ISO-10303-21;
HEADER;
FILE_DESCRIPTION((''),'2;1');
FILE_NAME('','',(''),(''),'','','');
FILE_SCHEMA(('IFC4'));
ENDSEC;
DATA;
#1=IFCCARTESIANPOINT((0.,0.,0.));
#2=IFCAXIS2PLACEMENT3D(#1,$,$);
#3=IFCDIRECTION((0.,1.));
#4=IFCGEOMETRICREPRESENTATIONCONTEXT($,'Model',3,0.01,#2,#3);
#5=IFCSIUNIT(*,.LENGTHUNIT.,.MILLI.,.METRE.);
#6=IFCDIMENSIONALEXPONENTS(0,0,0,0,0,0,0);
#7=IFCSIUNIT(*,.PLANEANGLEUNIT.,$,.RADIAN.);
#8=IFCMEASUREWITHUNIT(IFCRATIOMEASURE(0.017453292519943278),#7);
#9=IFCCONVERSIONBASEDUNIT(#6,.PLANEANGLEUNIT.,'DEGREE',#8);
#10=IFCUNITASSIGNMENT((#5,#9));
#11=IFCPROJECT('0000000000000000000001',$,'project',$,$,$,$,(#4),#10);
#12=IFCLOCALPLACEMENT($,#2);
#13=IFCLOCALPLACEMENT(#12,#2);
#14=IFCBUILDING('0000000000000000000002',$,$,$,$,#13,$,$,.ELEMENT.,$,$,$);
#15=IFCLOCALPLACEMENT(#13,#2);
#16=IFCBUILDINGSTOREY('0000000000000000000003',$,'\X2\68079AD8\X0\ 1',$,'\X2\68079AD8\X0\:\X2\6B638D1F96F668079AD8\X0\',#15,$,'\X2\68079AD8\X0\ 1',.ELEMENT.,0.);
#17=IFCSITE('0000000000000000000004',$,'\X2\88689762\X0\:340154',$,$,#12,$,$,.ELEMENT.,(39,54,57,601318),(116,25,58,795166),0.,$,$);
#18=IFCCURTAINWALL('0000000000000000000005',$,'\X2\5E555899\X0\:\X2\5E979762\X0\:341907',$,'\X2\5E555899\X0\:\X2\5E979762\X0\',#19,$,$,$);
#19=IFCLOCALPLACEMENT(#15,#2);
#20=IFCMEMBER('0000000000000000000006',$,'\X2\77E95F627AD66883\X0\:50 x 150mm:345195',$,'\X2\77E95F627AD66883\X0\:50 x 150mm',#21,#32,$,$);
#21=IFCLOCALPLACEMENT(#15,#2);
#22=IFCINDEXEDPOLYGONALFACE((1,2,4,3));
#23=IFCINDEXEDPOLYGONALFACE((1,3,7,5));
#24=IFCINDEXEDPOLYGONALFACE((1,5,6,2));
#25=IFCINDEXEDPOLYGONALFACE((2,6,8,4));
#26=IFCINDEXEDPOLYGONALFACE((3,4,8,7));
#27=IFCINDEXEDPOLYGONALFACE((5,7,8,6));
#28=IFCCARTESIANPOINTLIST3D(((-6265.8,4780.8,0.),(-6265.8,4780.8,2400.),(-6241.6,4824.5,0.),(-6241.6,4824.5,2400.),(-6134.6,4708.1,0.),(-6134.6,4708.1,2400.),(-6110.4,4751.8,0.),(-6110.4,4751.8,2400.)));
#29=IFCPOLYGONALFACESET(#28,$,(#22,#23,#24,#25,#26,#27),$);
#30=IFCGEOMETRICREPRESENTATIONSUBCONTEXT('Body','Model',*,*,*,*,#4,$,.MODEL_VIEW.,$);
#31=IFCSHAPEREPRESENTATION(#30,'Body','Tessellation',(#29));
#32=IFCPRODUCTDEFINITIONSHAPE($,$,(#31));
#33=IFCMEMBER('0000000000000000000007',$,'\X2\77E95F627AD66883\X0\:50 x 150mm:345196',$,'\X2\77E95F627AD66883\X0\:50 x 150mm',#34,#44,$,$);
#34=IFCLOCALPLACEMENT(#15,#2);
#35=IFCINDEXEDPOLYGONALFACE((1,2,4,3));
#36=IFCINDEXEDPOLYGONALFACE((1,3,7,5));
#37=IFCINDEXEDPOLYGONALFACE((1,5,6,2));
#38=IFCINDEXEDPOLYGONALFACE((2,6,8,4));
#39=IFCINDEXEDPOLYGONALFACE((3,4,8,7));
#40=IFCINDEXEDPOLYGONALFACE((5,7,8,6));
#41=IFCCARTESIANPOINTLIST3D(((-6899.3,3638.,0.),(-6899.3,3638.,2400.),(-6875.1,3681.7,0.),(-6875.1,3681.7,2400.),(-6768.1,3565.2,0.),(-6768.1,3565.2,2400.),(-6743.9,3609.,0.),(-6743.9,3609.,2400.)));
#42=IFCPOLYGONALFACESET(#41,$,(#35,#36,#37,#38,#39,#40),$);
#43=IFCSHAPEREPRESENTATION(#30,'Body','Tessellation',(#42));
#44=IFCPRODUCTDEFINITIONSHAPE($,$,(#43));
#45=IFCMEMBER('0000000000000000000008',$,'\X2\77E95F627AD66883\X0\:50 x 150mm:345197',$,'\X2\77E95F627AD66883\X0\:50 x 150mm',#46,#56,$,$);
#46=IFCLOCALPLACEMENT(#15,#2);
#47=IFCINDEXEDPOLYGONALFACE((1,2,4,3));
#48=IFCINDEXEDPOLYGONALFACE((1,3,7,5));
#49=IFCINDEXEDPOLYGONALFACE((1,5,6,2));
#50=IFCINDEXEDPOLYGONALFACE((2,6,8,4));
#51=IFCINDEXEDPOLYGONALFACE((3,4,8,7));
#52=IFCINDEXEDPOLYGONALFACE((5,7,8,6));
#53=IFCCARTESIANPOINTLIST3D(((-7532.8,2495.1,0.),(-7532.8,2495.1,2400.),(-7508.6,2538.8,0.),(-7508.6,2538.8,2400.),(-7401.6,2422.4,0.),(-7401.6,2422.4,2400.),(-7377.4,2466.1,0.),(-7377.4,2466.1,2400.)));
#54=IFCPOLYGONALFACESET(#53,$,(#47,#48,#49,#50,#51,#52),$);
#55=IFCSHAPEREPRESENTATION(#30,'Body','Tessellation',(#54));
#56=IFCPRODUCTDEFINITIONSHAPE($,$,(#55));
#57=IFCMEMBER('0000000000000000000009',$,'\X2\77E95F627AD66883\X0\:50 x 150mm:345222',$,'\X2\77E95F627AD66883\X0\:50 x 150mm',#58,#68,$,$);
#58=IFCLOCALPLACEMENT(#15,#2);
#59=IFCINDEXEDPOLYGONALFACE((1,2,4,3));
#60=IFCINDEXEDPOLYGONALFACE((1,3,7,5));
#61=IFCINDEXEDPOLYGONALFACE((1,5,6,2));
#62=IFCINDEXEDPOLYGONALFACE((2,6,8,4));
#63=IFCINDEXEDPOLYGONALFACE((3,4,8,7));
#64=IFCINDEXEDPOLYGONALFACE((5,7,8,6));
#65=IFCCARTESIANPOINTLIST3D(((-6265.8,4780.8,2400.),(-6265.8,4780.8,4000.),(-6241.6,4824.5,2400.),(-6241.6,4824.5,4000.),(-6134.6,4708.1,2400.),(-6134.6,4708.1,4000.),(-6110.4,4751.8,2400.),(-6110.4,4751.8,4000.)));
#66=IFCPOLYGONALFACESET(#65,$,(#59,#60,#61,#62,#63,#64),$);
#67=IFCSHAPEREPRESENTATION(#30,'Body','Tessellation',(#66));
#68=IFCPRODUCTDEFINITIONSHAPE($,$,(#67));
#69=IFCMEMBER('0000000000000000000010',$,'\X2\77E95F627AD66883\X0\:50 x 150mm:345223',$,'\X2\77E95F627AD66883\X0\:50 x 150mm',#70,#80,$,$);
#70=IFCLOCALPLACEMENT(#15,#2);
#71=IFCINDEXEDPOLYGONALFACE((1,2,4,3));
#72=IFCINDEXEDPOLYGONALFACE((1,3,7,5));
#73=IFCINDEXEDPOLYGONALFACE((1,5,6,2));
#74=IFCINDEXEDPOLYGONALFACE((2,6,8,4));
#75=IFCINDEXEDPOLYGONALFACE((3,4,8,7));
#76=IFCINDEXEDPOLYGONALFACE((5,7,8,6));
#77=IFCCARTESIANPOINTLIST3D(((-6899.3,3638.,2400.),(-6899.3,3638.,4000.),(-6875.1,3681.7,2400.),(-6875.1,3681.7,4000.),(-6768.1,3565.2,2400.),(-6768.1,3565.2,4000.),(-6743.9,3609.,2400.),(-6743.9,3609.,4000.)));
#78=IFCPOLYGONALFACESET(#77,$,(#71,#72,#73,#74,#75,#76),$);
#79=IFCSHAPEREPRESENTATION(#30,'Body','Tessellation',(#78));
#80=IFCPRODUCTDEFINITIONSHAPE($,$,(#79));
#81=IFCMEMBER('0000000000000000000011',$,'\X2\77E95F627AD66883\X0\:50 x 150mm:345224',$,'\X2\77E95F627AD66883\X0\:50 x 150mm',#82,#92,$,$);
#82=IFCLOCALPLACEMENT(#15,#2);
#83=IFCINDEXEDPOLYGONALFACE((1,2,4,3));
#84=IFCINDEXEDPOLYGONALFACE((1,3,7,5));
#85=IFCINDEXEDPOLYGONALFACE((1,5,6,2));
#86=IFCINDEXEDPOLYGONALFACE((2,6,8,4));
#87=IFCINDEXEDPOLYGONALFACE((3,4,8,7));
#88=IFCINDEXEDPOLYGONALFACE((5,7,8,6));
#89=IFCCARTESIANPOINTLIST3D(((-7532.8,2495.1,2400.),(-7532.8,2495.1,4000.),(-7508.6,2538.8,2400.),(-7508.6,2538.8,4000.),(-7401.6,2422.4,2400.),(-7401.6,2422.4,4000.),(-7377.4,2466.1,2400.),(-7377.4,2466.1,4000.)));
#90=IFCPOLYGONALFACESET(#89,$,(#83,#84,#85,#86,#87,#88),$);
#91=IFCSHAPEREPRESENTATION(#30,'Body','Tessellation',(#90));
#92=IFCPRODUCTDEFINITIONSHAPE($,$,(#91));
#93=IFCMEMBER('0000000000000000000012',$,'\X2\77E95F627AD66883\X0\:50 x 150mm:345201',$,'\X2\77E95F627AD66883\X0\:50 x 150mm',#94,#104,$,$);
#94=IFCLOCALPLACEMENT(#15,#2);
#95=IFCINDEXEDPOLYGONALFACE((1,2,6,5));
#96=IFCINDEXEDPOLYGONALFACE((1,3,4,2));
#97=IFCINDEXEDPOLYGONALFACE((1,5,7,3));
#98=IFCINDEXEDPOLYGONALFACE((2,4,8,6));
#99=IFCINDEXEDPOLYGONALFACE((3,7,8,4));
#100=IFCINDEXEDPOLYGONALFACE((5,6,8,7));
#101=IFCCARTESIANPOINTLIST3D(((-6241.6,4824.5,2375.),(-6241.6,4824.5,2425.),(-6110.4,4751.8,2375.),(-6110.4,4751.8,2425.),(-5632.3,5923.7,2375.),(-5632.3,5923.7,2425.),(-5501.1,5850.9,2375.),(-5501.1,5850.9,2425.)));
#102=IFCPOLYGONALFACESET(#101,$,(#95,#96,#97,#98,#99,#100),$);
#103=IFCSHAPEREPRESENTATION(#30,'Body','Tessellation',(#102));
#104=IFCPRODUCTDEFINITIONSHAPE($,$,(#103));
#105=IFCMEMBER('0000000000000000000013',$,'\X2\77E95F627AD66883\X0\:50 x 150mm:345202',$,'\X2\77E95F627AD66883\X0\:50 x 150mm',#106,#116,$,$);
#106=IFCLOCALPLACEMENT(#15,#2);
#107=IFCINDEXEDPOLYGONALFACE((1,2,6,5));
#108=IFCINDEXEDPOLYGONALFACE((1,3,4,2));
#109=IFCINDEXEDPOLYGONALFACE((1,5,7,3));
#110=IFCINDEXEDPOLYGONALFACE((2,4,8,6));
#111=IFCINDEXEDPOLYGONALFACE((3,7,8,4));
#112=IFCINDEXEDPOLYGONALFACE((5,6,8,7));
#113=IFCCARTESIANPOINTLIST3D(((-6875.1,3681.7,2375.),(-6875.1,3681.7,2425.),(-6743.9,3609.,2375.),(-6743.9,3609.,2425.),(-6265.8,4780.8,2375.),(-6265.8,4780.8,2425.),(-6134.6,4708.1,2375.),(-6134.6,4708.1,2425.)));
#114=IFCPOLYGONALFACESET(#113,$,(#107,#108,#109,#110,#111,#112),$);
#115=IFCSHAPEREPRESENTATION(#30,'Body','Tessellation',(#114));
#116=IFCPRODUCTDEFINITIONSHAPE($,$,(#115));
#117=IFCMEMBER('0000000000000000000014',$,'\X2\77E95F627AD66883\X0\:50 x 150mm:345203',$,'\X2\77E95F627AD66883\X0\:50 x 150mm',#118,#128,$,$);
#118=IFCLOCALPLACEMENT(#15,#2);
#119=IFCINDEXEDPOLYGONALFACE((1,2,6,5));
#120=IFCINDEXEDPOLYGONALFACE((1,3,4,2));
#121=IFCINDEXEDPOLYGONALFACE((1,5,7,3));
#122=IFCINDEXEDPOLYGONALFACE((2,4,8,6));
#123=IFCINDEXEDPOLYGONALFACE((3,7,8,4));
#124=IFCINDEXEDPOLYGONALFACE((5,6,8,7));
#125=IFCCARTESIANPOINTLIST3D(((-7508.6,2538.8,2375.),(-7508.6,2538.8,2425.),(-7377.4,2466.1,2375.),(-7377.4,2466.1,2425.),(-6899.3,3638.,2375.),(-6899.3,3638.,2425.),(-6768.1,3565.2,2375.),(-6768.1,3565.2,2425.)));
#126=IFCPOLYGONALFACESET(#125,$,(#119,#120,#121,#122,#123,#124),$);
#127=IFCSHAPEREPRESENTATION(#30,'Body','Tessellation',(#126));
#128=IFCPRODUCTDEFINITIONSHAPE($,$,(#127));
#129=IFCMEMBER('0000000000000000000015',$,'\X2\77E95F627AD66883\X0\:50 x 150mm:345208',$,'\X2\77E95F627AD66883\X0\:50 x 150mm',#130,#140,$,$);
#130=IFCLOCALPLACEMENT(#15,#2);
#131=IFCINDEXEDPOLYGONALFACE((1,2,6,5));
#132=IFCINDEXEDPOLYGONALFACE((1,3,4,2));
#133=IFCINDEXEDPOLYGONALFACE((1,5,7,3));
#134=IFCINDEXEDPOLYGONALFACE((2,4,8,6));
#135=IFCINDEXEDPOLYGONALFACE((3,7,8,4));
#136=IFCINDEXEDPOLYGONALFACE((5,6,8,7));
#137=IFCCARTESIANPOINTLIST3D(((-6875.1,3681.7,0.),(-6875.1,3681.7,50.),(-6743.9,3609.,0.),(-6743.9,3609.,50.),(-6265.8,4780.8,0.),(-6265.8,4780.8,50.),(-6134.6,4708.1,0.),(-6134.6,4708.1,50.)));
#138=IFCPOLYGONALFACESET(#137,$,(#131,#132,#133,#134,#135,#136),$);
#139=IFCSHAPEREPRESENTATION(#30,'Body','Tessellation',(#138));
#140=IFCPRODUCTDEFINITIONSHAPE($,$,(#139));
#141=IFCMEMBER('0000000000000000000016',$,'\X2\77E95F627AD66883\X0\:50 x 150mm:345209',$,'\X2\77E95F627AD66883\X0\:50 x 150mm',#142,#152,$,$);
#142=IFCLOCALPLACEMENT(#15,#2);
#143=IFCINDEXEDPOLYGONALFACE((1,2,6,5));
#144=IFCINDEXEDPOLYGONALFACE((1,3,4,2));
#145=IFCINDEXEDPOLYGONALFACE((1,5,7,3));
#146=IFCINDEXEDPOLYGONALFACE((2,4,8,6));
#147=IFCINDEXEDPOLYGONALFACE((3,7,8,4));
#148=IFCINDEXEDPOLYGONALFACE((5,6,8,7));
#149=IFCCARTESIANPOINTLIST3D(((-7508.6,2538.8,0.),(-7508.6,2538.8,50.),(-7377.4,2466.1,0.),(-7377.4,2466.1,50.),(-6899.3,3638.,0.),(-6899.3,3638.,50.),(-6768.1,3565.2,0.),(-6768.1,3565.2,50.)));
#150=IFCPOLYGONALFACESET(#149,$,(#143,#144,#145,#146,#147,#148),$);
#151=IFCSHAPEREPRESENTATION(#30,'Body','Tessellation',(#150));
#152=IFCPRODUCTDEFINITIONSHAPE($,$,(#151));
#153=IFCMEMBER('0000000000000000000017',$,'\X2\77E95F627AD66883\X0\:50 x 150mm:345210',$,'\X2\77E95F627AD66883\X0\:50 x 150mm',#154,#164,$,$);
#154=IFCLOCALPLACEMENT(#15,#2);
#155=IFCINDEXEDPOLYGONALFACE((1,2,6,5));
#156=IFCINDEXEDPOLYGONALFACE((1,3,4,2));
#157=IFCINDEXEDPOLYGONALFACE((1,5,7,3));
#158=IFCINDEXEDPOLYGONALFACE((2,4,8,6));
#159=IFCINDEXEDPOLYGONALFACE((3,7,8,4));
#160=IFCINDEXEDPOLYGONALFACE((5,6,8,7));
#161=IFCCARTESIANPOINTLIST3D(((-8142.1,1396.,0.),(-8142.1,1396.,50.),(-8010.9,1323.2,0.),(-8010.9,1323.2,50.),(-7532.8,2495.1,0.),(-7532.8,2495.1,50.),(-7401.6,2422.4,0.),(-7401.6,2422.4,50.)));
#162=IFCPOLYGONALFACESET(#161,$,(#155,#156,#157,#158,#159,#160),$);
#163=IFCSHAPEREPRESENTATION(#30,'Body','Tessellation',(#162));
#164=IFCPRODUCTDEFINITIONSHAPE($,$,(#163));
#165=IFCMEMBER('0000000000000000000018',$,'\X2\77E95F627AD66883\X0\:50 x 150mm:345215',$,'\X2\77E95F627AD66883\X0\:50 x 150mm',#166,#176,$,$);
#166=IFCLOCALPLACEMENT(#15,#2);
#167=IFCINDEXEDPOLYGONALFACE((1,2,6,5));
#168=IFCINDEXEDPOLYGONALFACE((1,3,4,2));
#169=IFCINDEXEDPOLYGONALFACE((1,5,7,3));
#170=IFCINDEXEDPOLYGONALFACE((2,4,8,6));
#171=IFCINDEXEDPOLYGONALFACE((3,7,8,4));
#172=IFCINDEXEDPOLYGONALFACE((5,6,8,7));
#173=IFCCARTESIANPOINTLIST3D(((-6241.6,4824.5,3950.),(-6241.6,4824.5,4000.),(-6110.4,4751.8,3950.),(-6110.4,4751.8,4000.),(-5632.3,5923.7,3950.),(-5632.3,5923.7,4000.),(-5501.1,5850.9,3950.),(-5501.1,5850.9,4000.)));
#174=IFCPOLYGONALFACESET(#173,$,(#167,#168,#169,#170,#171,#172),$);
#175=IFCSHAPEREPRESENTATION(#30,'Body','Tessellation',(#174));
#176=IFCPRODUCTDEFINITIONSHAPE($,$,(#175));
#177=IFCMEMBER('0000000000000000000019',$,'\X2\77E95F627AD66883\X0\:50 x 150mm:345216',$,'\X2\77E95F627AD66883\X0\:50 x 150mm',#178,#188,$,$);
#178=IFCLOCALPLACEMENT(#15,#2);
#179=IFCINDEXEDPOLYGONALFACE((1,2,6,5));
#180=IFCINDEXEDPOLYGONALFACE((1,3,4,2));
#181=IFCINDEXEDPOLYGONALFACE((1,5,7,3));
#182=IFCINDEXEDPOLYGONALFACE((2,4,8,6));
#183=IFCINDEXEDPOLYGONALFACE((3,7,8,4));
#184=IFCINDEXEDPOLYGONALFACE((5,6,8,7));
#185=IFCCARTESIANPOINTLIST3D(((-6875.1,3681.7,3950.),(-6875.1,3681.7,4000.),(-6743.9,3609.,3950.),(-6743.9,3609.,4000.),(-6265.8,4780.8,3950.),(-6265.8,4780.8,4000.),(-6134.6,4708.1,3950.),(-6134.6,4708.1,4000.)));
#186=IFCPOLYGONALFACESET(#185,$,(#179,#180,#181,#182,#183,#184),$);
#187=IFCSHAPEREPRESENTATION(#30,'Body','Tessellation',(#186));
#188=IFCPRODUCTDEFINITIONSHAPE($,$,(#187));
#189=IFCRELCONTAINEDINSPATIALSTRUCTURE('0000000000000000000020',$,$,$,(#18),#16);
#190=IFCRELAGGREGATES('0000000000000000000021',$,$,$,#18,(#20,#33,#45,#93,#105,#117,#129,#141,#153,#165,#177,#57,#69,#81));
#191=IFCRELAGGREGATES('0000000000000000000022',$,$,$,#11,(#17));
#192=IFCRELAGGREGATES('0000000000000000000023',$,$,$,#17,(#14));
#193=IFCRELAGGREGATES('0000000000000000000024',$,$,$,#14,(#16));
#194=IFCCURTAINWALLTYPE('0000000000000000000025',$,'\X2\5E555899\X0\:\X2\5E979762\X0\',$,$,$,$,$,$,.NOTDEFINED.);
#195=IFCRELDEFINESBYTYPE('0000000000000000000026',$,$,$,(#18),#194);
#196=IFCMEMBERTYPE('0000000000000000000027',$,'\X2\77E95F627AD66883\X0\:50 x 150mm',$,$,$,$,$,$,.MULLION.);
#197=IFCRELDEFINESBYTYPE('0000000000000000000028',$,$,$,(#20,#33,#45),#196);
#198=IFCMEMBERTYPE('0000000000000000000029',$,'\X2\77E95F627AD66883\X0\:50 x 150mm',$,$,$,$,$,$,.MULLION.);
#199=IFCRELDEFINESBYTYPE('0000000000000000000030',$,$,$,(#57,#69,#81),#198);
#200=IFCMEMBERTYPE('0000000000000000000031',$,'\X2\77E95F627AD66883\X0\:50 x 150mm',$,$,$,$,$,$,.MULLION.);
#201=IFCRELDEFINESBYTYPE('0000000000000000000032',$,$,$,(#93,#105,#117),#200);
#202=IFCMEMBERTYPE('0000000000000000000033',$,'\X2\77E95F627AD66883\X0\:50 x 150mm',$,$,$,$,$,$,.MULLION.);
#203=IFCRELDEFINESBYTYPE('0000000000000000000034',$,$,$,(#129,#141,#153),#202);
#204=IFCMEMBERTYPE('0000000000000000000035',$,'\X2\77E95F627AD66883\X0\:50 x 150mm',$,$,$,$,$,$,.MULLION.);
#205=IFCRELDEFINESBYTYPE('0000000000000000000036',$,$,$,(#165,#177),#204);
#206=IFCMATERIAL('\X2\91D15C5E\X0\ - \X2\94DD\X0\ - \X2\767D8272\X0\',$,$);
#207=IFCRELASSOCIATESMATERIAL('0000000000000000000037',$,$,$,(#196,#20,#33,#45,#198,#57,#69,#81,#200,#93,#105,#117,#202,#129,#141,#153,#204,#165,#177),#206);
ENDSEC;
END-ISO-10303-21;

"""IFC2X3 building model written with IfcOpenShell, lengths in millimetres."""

from ifc_helpers import new_model, entity, si_unit, converted_unit, direction, frame, origin, origin_2d_with_axis, place, context, subcontext, project, spatial, rectangle, extrude, source, transform, mapped, material, type_object, type_shapes, element, aggregate, save


model = new_model("IFC2X3")

# Units and contexts
model_context = context("Model", 3, precision=0.01, world=origin(), true_north=direction((0.0, 1.0)))
body_context = subcontext(model_context, "Body", "Model", "MODEL_VIEW")
ifc_project = project(units=[si_unit("LENGTHUNIT", "METRE", prefix="MILLI"), converted_unit("PLANEANGLEUNIT", "DEGREE", entity("IfcRatioMeasure", 0.017453292519943278), si_unit("PLANEANGLEUNIT", "RADIAN"), dimensions=[0, 0, 0, 0, 0, 0, 0])], contexts=[model_context])

# Site, building, storey
site_placement = place(None, origin())
site = spatial("IfcSite", under=ifc_project, at=site_placement, Name="表面:340154", CompositionType="ELEMENT", RefLatitude=(39, 54, 57, 601318), RefLongitude=(116, 25, 58, 795166), RefElevation=0.0)
building_placement = place(site_placement, origin())
building = spatial("IfcBuilding", under=site, at=building_placement, CompositionType="ELEMENT")
storey_placement = place(building_placement, origin())
storey = spatial("IfcBuildingStorey", under=building, at=storey_placement, Name="标高 1", ObjectType="标高:正负零标高", LongName="标高 1", CompositionType="ELEMENT", Elevation=0.0)

# Curtain wall, members
curtain_wall_type = type_object("IfcCurtainWallType", Name="幕墙:店面", PredefinedType="NOTDEFINED")
curtain_wall_placement = place(storey_placement, origin())
curtain_wall = element("IfcCurtainWall", 1, at=curtain_wall_placement, inside=storey, type_object=curtain_wall_type, Name="幕墙:店面:341907", ObjectType="幕墙:店面")
ifc_material_1 = material(Name="金属 - 铝 - 白色")
member_type_1 = type_object("IfcMemberType", Name="矩形竖梃:50 x 150mm", PredefinedType="MULLION", material=ifc_material_1)
shared_shape_1 = source(origin(), body_context, "Body", "SweptSolid", [
    extrude(rectangle(XDim=150.0, YDim=50.0, at=origin_2d_with_axis()), frame((0.0, 0.0, -2400.0), z_axis=(0.0, 0.0, 1.0), x_axis=(0.0, -1.0, 0.0)), (0.0, 0.0, 1.0), 2400.0),
])
type_shapes(member_type_1, [shared_shape_1])
member_1_placement = place(curtain_wall_placement, frame((-6188.1, 4766.3, 0.0), z_axis=(0.0, 0.0, -1.0), x_axis=(-0.48481, -0.87462, 0.0)))
member_1 = element("IfcMember", 2, at=member_1_placement, type_object=member_type_1, material=ifc_material_1, Name="矩形竖梃:50 x 150mm:345195", ObjectType="矩形竖梃:50 x 150mm", context=body_context, shape_type="MappedRepresentation", body=[
    mapped(shared_shape_1, transform((0.0, 0.0, 0.0), scale=1.0)),
])
member_2_placement = place(curtain_wall_placement, frame((-6821.6, 3623.5, 0.0), z_axis=(0.0, 0.0, -1.0), x_axis=(-0.48481, -0.87462, 0.0)))
member_2 = element("IfcMember", 3, at=member_2_placement, type_object=member_type_1, material=ifc_material_1, Name="矩形竖梃:50 x 150mm:345196", ObjectType="矩形竖梃:50 x 150mm", context=body_context, shape_type="MappedRepresentation", body=[
    mapped(shared_shape_1, transform((0.0, 0.0, 0.0), scale=1.0)),
])
member_3_placement = place(curtain_wall_placement, frame((-7455.1, 2480.6, 0.0), z_axis=(0.0, 0.0, -1.0), x_axis=(-0.48481, -0.87462, 0.0)))
member_3 = element("IfcMember", 4, at=member_3_placement, type_object=member_type_1, material=ifc_material_1, Name="矩形竖梃:50 x 150mm:345197", ObjectType="矩形竖梃:50 x 150mm", context=body_context, shape_type="MappedRepresentation", body=[
    mapped(shared_shape_1, transform((0.0, 0.0, 0.0), scale=1.0)),
])
member_type_2 = type_object("IfcMemberType", Name="矩形竖梃:50 x 150mm", PredefinedType="MULLION", material=ifc_material_1)
shared_shape_2 = source(origin(), body_context, "Body", "SweptSolid", [
    extrude(rectangle(XDim=150.0, YDim=50.0, at=origin_2d_with_axis()), frame((0.0, 0.0, -1600.0), z_axis=(0.0, 0.0, 1.0), x_axis=(0.0, -1.0, 0.0)), (0.0, 0.0, 1.0), 1600.0),
])
type_shapes(member_type_2, [shared_shape_2])
member_4_placement = place(curtain_wall_placement, frame((-6188.1, 4766.3, 2400.0), z_axis=(0.0, 0.0, -1.0), x_axis=(-0.48481, -0.87462, 0.0)))
member_4 = element("IfcMember", 5, at=member_4_placement, type_object=member_type_2, material=ifc_material_1, Name="矩形竖梃:50 x 150mm:345222", ObjectType="矩形竖梃:50 x 150mm", context=body_context, shape_type="MappedRepresentation", body=[
    mapped(shared_shape_2, transform((0.0, 0.0, 0.0), scale=1.0)),
])
member_5_placement = place(curtain_wall_placement, frame((-6821.6, 3623.5, 2400.0), z_axis=(0.0, 0.0, -1.0), x_axis=(-0.48481, -0.87462, 0.0)))
member_5 = element("IfcMember", 6, at=member_5_placement, type_object=member_type_2, material=ifc_material_1, Name="矩形竖梃:50 x 150mm:345223", ObjectType="矩形竖梃:50 x 150mm", context=body_context, shape_type="MappedRepresentation", body=[
    mapped(shared_shape_2, transform((0.0, 0.0, 0.0), scale=1.0)),
])
member_6_placement = place(curtain_wall_placement, frame((-7455.1, 2480.6, 2400.0), z_axis=(0.0, 0.0, -1.0), x_axis=(-0.48481, -0.87462, 0.0)))
member_6 = element("IfcMember", 7, at=member_6_placement, type_object=member_type_2, material=ifc_material_1, Name="矩形竖梃:50 x 150mm:345224", ObjectType="矩形竖梃:50 x 150mm", context=body_context, shape_type="MappedRepresentation", body=[
    mapped(shared_shape_2, transform((0.0, 0.0, 0.0), scale=1.0)),
])
member_type_3 = type_object("IfcMemberType", Name="矩形竖梃:50 x 150mm", PredefinedType="MULLION", material=ifc_material_1)
shared_shape_3 = source(origin(), body_context, "Body", "SweptSolid", [
    extrude(rectangle(XDim=150.0, YDim=50.0, at=origin_2d_with_axis()), frame((0.0, 0.0, -1256.7), z_axis=(0.0, 0.0, 1.0), x_axis=(0.0, -1.0, 0.0)), (0.0, 0.0, 1.0), 1256.7),
])
type_shapes(member_type_3, [shared_shape_3])
member_7_placement = place(curtain_wall_placement, frame((-6176.0, 4788.2, 2400.0), z_axis=(-0.48481, -0.87462, 0.0), x_axis=(0.0, 0.0, 1.0)))
member_7 = element("IfcMember", 8, at=member_7_placement, type_object=member_type_3, material=ifc_material_1, Name="矩形竖梃:50 x 150mm:345201", ObjectType="矩形竖梃:50 x 150mm", context=body_context, shape_type="MappedRepresentation", body=[
    mapped(shared_shape_3, transform((0.0, 0.0, 0.0), scale=1.0)),
])
member_8_placement = place(curtain_wall_placement, frame((-6809.5, 3645.3, 2400.0), z_axis=(-0.48481, -0.87462, 0.0), x_axis=(0.0, 0.0, 1.0)))
member_8 = element("IfcMember", 9, at=member_8_placement, type_object=member_type_3, material=ifc_material_1, Name="矩形竖梃:50 x 150mm:345202", ObjectType="矩形竖梃:50 x 150mm", context=body_context, shape_type="MappedRepresentation", body=[
    mapped(shared_shape_3, transform((0.0, 0.0, 0.0), scale=1.0)),
])
member_9_placement = place(curtain_wall_placement, frame((-7443.0, 2502.5, 2400.0), z_axis=(-0.48481, -0.87462, 0.0), x_axis=(0.0, 0.0, 1.0)))
member_9 = element("IfcMember", 10, at=member_9_placement, type_object=member_type_3, material=ifc_material_1, Name="矩形竖梃:50 x 150mm:345203", ObjectType="矩形竖梃:50 x 150mm", context=body_context, shape_type="MappedRepresentation", body=[
    mapped(shared_shape_3, transform((0.0, 0.0, 0.0), scale=1.0)),
])
member_type_4 = type_object("IfcMemberType", Name="矩形竖梃:50 x 150mm", PredefinedType="MULLION", material=ifc_material_1)
shared_shape_4 = source(origin(), body_context, "Body", "SweptSolid", [
    extrude(rectangle(XDim=150.0, YDim=50.0, at=origin_2d_with_axis()), frame((-25.0, 0.0, -1256.7), z_axis=(0.0, 0.0, 1.0), x_axis=(0.0, -1.0, 0.0)), (0.0, 0.0, 1.0), 1256.7),
])
type_shapes(member_type_4, [shared_shape_4])
member_10_placement = place(curtain_wall_placement, frame((-6200.2, 4744.4, 0.0), z_axis=(0.48481, 0.87462, 0.0), x_axis=(0.0, 0.0, -1.0)))
member_10 = element("IfcMember", 11, at=member_10_placement, type_object=member_type_4, material=ifc_material_1, Name="矩形竖梃:50 x 150mm:345208", ObjectType="矩形竖梃:50 x 150mm", context=body_context, shape_type="MappedRepresentation", body=[
    mapped(shared_shape_4, transform((0.0, 0.0, 0.0), scale=1.0)),
])
member_11_placement = place(curtain_wall_placement, frame((-6833.7, 3601.6, 0.0), z_axis=(0.48481, 0.87462, 0.0), x_axis=(0.0, 0.0, -1.0)))
member_11 = element("IfcMember", 12, at=member_11_placement, type_object=member_type_4, material=ifc_material_1, Name="矩形竖梃:50 x 150mm:345209", ObjectType="矩形竖梃:50 x 150mm", context=body_context, shape_type="MappedRepresentation", body=[
    mapped(shared_shape_4, transform((0.0, 0.0, 0.0), scale=1.0)),
])
member_12_placement = place(curtain_wall_placement, frame((-7467.2, 2458.7, 0.0), z_axis=(0.48481, 0.87462, 0.0), x_axis=(0.0, 0.0, -1.0)))
member_12 = element("IfcMember", 13, at=member_12_placement, type_object=member_type_4, material=ifc_material_1, Name="矩形竖梃:50 x 150mm:345210", ObjectType="矩形竖梃:50 x 150mm", context=body_context, shape_type="MappedRepresentation", body=[
    mapped(shared_shape_4, transform((0.0, 0.0, 0.0), scale=1.0)),
])
member_type_5 = type_object("IfcMemberType", Name="矩形竖梃:50 x 150mm", PredefinedType="MULLION", material=ifc_material_1)
shared_shape_5 = source(origin(), body_context, "Body", "SweptSolid", [
    extrude(rectangle(XDim=150.0, YDim=50.0, at=origin_2d_with_axis()), frame((-25.0, 0.0, -1256.7), z_axis=(0.0, 0.0, 1.0), x_axis=(0.0, -1.0, 0.0)), (0.0, 0.0, 1.0), 1256.7),
])
type_shapes(member_type_5, [shared_shape_5])
member_13_placement = place(curtain_wall_placement, frame((-6176.0, 4788.2, 4000.0), z_axis=(-0.48481, -0.87462, 0.0), x_axis=(0.0, 0.0, 1.0)))
member_13 = element("IfcMember", 14, at=member_13_placement, type_object=member_type_5, material=ifc_material_1, Name="矩形竖梃:50 x 150mm:345215", ObjectType="矩形竖梃:50 x 150mm", context=body_context, shape_type="MappedRepresentation", body=[
    mapped(shared_shape_5, transform((0.0, 0.0, 0.0), scale=1.0)),
])
member_14_placement = place(curtain_wall_placement, frame((-6809.5, 3645.3, 4000.0), z_axis=(-0.48481, -0.87462, 0.0), x_axis=(0.0, 0.0, 1.0)))
member_14 = element("IfcMember", 15, at=member_14_placement, type_object=member_type_5, material=ifc_material_1, Name="矩形竖梃:50 x 150mm:345216", ObjectType="矩形竖梃:50 x 150mm", context=body_context, shape_type="MappedRepresentation", body=[
    mapped(shared_shape_5, transform((0.0, 0.0, 0.0), scale=1.0)),
])
aggregate(curtain_wall, [member_1, member_2, member_3, member_7, member_8, member_9, member_10, member_11, member_12, member_13, member_14, member_4, member_5, member_6])

save(model, "model.ifc")
